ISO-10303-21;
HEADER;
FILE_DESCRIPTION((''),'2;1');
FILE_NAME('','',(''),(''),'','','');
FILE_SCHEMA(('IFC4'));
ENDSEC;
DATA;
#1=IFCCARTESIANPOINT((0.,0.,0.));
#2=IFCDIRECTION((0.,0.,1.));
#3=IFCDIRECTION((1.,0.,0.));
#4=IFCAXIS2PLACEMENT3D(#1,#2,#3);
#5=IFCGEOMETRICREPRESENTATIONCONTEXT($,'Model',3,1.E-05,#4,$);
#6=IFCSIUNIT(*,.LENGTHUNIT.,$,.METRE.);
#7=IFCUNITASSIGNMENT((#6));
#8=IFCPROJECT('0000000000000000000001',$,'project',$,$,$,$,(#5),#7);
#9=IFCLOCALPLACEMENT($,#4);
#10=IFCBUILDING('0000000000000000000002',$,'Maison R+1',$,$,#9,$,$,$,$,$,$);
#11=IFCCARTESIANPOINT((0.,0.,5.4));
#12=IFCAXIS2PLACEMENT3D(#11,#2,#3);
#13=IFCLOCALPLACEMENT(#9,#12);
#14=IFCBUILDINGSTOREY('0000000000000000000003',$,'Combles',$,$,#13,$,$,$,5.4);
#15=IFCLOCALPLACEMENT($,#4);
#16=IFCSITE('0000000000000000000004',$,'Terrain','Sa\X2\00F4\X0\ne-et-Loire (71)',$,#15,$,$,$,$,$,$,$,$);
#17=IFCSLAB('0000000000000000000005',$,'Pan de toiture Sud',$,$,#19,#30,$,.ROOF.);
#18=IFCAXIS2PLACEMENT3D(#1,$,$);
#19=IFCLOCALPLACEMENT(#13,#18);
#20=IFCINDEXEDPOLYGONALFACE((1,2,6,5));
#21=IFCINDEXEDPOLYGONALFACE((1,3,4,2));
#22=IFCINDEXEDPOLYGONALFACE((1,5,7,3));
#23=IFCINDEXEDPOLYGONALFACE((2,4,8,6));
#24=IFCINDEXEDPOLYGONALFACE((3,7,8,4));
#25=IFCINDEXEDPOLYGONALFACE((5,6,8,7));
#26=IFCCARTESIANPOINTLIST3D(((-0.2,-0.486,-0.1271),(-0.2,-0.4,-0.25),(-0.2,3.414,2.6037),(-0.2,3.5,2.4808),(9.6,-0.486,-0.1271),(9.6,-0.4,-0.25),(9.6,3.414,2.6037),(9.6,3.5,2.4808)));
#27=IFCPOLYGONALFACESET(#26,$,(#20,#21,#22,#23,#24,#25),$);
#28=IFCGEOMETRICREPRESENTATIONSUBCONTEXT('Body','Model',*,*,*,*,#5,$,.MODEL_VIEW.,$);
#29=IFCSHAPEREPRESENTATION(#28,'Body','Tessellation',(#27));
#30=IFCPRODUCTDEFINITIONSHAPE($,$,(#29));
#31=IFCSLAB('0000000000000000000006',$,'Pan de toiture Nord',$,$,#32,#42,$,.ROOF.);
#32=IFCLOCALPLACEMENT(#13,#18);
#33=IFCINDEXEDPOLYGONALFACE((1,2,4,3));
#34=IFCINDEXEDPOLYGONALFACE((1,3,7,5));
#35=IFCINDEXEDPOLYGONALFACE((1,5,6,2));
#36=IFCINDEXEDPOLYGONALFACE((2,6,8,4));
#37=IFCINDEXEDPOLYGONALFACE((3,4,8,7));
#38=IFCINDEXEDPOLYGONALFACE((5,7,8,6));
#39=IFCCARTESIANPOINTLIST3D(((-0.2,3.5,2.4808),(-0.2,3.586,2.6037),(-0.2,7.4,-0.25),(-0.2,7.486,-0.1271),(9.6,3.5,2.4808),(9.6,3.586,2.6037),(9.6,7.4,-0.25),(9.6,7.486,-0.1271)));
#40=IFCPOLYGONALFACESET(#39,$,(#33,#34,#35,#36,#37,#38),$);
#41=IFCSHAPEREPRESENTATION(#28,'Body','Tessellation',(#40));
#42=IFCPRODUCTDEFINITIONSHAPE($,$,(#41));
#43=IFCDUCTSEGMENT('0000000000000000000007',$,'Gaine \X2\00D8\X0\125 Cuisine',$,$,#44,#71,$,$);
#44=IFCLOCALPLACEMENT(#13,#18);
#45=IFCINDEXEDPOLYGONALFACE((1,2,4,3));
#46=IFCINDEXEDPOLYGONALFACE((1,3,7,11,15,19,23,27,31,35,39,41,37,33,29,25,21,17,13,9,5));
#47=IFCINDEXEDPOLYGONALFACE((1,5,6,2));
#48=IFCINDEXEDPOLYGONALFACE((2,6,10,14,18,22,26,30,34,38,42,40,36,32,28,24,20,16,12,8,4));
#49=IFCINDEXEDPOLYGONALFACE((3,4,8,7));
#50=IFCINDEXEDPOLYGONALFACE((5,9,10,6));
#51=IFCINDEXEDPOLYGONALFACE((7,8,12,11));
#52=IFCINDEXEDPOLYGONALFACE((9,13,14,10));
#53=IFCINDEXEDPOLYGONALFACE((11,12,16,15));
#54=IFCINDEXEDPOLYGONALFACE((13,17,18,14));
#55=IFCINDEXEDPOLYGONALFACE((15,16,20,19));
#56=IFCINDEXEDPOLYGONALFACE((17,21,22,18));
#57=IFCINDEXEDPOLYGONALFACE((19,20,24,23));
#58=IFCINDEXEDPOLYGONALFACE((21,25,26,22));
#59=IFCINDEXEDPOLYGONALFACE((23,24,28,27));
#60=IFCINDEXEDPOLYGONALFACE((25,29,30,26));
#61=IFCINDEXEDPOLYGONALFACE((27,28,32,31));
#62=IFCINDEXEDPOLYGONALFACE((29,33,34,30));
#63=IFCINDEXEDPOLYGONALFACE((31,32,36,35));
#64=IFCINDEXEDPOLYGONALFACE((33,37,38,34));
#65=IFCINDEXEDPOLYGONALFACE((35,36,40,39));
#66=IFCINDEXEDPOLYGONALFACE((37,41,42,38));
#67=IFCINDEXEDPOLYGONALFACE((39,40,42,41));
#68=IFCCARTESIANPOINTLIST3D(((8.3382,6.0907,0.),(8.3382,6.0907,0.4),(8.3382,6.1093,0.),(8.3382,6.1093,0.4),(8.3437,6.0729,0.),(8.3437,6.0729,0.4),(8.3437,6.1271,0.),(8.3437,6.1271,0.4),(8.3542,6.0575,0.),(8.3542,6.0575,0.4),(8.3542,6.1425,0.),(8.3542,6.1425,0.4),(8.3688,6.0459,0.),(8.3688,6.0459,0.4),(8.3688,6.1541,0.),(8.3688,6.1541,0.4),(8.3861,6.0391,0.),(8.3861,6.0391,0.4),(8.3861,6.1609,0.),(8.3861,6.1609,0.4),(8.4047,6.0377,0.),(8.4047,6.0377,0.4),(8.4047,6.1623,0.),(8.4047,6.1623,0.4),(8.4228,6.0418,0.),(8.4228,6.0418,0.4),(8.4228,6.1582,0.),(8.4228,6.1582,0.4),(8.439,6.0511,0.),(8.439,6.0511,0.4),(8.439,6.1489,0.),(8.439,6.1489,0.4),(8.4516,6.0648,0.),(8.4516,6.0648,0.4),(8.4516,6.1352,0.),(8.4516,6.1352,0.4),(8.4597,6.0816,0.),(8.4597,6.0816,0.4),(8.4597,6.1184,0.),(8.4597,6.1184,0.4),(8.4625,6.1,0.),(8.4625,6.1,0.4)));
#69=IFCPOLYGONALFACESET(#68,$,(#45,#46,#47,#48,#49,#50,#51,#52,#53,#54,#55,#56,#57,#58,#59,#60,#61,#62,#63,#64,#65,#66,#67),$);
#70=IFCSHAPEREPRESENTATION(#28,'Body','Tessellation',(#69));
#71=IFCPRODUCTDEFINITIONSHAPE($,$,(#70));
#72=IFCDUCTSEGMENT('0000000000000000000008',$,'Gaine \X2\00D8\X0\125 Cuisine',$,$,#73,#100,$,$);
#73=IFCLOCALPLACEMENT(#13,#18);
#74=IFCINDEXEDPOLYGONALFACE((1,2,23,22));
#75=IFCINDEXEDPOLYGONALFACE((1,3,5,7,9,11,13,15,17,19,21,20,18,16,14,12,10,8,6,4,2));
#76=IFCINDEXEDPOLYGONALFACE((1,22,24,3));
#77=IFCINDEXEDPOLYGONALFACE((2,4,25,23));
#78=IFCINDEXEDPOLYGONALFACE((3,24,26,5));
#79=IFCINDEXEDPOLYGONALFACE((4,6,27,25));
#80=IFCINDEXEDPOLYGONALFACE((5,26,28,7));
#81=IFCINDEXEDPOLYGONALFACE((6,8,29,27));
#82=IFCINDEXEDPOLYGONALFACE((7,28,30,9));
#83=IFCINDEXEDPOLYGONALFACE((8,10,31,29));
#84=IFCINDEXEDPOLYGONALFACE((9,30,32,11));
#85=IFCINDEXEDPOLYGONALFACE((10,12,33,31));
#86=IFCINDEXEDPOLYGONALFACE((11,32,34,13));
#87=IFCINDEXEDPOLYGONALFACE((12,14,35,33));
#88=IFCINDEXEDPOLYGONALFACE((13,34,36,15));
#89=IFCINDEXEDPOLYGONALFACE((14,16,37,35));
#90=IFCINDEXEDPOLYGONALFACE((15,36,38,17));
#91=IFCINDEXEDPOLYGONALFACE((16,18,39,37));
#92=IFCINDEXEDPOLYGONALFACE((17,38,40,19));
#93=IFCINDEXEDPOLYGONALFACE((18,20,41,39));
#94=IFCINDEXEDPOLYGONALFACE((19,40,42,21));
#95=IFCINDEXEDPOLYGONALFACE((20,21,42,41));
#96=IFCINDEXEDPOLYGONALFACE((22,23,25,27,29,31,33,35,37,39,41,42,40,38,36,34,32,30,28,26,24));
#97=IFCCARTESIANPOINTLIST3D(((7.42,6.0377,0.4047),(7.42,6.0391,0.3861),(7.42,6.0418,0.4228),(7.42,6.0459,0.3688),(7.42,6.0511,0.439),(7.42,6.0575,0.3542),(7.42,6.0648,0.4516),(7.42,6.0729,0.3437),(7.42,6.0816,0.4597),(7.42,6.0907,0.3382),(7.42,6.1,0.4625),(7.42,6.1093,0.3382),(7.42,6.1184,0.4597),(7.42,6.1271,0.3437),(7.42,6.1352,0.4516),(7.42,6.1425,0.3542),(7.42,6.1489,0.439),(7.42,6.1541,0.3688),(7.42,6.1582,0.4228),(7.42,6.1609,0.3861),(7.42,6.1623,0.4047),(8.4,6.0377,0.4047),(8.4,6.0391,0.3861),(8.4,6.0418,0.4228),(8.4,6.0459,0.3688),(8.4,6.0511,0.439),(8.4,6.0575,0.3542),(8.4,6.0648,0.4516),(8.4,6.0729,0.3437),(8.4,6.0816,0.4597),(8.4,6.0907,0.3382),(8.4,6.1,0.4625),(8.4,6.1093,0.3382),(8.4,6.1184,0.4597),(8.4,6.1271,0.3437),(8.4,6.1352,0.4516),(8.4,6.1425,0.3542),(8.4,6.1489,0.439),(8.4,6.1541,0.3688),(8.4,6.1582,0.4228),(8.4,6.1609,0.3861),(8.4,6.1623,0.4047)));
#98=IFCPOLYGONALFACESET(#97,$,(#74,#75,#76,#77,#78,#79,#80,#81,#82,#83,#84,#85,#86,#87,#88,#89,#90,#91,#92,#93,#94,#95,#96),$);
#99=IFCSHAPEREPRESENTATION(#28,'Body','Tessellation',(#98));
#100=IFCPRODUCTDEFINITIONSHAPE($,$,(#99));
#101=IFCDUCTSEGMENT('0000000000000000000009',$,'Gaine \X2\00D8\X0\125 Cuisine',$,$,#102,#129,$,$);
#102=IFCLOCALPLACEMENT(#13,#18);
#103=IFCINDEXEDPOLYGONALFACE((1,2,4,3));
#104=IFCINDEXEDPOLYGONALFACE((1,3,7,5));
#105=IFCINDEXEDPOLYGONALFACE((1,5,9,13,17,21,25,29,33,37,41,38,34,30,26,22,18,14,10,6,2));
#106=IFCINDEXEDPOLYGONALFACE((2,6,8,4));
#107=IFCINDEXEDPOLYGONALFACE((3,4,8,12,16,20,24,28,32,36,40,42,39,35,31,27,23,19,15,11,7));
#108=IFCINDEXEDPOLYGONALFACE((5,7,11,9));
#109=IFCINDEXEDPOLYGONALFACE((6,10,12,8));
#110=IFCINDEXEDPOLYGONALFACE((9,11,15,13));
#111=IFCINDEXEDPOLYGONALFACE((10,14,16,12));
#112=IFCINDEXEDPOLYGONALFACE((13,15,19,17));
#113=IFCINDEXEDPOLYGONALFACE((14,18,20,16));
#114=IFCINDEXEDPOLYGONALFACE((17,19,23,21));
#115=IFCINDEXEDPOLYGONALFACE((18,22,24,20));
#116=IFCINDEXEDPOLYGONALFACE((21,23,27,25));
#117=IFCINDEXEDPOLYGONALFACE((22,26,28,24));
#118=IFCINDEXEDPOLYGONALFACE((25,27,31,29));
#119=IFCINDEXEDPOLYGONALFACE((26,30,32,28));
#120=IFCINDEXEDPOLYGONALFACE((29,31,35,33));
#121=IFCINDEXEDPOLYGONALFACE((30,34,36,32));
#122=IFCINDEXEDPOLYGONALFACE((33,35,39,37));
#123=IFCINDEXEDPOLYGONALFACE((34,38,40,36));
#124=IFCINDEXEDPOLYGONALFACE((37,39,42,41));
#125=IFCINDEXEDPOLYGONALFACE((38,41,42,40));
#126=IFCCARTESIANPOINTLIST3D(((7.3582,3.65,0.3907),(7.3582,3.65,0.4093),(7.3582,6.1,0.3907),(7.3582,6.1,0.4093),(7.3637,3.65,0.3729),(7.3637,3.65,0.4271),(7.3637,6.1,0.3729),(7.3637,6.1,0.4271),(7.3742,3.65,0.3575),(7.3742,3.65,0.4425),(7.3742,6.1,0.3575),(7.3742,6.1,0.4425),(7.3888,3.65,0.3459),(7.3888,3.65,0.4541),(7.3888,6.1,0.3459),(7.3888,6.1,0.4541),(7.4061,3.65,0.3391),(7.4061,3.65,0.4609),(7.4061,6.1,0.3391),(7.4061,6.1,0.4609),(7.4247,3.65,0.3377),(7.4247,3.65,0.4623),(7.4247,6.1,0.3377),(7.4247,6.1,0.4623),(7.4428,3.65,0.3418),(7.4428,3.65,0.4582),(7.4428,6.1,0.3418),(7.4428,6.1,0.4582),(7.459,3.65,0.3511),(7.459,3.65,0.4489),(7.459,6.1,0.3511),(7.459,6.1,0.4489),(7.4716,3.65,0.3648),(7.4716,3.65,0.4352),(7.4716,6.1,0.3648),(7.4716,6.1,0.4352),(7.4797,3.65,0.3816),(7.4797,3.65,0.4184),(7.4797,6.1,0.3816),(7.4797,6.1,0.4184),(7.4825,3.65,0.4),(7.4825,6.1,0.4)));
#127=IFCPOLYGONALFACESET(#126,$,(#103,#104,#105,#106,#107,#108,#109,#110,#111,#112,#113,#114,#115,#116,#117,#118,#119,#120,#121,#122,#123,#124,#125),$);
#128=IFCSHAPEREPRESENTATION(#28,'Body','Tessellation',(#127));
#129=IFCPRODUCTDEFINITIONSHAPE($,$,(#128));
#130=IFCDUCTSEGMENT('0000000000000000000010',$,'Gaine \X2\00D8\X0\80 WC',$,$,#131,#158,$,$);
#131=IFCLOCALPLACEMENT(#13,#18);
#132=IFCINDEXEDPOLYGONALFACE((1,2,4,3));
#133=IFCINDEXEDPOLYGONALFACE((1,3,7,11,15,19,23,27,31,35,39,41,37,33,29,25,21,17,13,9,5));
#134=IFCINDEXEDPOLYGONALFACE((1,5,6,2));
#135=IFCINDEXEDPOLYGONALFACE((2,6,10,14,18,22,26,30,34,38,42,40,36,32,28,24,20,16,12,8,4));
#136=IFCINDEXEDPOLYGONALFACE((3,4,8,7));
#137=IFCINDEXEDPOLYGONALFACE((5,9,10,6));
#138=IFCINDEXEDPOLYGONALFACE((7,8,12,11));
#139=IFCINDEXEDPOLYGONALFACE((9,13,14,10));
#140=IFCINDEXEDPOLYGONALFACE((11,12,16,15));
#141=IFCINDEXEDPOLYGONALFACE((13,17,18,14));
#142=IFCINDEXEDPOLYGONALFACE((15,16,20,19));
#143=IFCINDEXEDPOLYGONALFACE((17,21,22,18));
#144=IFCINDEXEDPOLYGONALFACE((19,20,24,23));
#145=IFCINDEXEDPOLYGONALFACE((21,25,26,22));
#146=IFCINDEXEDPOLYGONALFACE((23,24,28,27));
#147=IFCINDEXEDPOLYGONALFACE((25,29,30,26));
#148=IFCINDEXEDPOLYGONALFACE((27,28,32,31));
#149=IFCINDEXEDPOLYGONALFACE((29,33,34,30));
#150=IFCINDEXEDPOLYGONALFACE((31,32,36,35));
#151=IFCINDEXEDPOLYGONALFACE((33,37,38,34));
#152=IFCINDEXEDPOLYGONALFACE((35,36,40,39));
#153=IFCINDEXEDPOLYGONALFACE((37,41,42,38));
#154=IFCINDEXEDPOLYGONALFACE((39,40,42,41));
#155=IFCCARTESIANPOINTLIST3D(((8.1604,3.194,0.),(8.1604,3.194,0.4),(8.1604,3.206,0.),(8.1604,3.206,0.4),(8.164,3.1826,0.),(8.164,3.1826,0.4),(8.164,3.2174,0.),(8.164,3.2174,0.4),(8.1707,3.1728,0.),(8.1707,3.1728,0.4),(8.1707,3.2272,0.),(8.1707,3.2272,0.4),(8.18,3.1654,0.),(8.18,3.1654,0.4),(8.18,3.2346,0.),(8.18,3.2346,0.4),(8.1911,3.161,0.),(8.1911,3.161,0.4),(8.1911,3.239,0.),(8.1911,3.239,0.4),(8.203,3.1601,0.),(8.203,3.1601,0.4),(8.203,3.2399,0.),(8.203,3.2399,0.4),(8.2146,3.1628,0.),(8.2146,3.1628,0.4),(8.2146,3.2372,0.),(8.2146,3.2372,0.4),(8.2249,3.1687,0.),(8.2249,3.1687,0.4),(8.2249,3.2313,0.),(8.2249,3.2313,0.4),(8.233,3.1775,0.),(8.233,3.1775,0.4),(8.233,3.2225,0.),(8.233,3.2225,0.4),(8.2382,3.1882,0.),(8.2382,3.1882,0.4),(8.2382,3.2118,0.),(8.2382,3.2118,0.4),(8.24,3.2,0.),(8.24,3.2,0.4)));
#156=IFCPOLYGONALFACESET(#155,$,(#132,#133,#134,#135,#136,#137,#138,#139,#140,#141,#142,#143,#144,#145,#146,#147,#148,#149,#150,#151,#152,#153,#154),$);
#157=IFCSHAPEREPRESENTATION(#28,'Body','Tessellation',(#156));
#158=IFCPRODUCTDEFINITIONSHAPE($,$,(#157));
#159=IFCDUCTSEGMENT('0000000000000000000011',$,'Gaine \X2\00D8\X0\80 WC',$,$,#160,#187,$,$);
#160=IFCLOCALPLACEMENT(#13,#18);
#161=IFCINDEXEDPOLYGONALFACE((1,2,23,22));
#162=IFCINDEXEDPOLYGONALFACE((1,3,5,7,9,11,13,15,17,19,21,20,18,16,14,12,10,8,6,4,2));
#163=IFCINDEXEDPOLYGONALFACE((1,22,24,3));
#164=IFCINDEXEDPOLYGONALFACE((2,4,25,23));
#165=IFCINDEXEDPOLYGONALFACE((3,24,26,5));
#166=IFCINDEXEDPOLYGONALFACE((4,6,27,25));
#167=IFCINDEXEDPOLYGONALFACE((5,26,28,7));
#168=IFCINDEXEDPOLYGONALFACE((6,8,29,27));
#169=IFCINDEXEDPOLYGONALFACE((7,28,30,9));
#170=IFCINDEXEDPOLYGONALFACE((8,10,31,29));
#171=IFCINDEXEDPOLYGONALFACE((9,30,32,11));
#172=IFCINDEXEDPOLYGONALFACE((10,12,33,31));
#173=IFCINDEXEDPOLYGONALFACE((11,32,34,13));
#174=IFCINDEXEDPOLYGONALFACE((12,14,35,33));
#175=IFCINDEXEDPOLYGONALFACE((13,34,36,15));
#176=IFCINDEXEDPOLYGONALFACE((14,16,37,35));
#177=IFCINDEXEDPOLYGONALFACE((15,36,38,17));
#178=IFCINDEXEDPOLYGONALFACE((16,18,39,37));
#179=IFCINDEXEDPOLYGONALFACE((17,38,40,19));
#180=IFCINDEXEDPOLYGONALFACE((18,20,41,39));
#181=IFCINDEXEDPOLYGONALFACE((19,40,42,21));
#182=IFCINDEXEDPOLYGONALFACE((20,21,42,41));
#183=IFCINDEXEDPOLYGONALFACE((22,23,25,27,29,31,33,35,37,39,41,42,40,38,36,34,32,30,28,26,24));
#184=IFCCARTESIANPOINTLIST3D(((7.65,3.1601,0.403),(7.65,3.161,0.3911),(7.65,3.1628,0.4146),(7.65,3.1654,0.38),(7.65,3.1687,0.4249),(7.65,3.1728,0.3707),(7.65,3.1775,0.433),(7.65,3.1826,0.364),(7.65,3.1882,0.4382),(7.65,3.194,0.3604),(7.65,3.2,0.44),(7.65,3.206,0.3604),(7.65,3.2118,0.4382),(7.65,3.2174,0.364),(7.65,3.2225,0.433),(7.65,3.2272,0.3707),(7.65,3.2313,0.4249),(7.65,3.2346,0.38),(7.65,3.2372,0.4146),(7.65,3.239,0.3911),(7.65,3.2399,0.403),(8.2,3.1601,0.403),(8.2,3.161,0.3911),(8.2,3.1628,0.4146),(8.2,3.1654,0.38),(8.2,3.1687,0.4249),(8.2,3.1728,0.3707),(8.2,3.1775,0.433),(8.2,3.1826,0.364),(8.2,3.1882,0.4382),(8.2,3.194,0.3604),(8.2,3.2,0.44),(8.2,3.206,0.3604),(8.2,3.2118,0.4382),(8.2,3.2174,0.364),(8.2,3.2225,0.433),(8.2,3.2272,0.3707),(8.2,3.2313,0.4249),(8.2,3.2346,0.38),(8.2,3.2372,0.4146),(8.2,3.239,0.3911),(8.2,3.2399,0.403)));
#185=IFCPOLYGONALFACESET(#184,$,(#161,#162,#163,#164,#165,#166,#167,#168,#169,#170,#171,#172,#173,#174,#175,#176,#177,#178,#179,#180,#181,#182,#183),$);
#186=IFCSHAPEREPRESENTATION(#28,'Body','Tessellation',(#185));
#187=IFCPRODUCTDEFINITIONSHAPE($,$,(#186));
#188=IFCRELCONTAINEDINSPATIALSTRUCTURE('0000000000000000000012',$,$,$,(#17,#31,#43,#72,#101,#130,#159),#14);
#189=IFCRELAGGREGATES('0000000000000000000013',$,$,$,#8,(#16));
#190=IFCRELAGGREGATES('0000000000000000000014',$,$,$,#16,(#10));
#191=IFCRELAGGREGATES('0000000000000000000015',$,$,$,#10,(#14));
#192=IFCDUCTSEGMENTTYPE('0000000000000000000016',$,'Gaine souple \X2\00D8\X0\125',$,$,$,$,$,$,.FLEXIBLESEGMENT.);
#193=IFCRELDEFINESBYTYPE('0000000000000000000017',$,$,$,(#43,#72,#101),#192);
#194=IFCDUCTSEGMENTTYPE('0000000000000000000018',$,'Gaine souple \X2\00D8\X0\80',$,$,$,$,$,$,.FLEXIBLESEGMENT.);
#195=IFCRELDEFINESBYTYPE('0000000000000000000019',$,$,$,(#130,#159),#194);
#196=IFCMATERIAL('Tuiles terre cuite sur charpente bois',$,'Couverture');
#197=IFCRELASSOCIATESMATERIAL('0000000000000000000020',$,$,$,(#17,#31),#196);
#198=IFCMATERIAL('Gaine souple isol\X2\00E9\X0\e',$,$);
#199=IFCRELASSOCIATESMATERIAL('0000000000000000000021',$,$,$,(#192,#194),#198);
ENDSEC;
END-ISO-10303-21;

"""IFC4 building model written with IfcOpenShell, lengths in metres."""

from ifc_helpers import new_model, si_unit, frame, frame_2d, origin_with_axes, place, context, subcontext, project, spatial, rectangle, circle, extrude, material, type_object, element, save


model = new_model("IFC4")

# Units and contexts
model_context = context("Model", 3, precision=1e-05, world=origin_with_axes())
body_context = subcontext(model_context, "Body", "Model", "MODEL_VIEW")
ifc_project = project(units=[si_unit("LENGTHUNIT", "METRE")], contexts=[model_context])

# Site, building, storey
site_placement = place(None, origin_with_axes())
site = spatial("IfcSite", under=ifc_project, at=site_placement, Name="Terrain", Description="Saône-et-Loire (71)")
building_placement = place(None, origin_with_axes())
building = spatial("IfcBuilding", under=site, at=building_placement, Name="Maison R+1")
storey_placement = place(building_placement, frame((0.0, 0.0, 5.4), z_axis=(0.0, 0.0, 1.0), x_axis=(1.0, 0.0, 0.0)))
storey = spatial("IfcBuildingStorey", under=building, at=storey_placement, Name="Combles", Elevation=5.4)

# Slabs
ifc_material_1 = material(Name="Tuiles terre cuite sur charpente bois", Category="Couverture")
for number, where, z_axis, x_axis, name in (
    (1, (-0.2, -0.4, -0.25), (0.0, -0.573576, 0.819152), (1.0, 0.0, 0.0), "Pan de toiture Sud"),
    (2, (-0.2, 3.5, 2.4808), (0.0, 0.573576, 0.819152), (1.0, 0.0, 0.0), "Pan de toiture Nord"),
):
    element("IfcSlab", number, at=place(storey_placement, frame(where, z_axis=z_axis, x_axis=x_axis)), inside=storey, material=ifc_material_1, Name=name, PredefinedType="ROOF", context=body_context, shape_type="SweptSolid", body=[
        extrude(rectangle(XDim=9.8, YDim=4.761, at=frame_2d((4.9, 2.3805))), origin_with_axes(), (0.0, 0.0, 1.0), 0.15),
    ])

# Duct segments
ifc_material_2 = material(Name="Gaine souple isolée")
duct_segment_type_1 = type_object("IfcDuctSegmentType", Name="Gaine souple Ø125", PredefinedType="FLEXIBLESEGMENT", material=ifc_material_2)
duct_segment_1_placement = place(storey_placement, frame((8.4, 6.1, 0.0), z_axis=(0.0, 0.0, 1.0), x_axis=(1.0, 0.0, 0.0)))
element("IfcDuctSegment", 3, at=duct_segment_1_placement, inside=storey, type_object=duct_segment_type_1, Name="Gaine Ø125 Cuisine", context=body_context, shape_type="SweptSolid", body=[
    extrude(circle(Radius=0.0625), origin_with_axes(), (0.0, 0.0, 1.0), 0.4),
])
duct_segment_2_placement = place(storey_placement, frame((8.4, 6.1, 0.4), z_axis=(-1.0, 0.0, 0.0), x_axis=(0.0, 0.0, 1.0)))
element("IfcDuctSegment", 4, at=duct_segment_2_placement, inside=storey, type_object=duct_segment_type_1, Name="Gaine Ø125 Cuisine", context=body_context, shape_type="SweptSolid", body=[
    extrude(circle(Radius=0.0625), origin_with_axes(), (0.0, 0.0, 1.0), 0.98),
])
duct_segment_3_placement = place(storey_placement, frame((7.42, 6.1, 0.4), z_axis=(0.0, -1.0, 0.0), x_axis=(1.0, 0.0, 0.0)))
element("IfcDuctSegment", 5, at=duct_segment_3_placement, inside=storey, type_object=duct_segment_type_1, Name="Gaine Ø125 Cuisine", context=body_context, shape_type="SweptSolid", body=[
    extrude(circle(Radius=0.0625), origin_with_axes(), (0.0, 0.0, 1.0), 2.45),
])
duct_segment_type_2 = type_object("IfcDuctSegmentType", Name="Gaine souple Ø80", PredefinedType="FLEXIBLESEGMENT", material=ifc_material_2)
duct_segment_4_placement = place(storey_placement, frame((8.2, 3.2, 0.0), z_axis=(0.0, 0.0, 1.0), x_axis=(1.0, 0.0, 0.0)))
element("IfcDuctSegment", 6, at=duct_segment_4_placement, inside=storey, type_object=duct_segment_type_2, Name="Gaine Ø80 WC", context=body_context, shape_type="SweptSolid", body=[
    extrude(circle(Radius=0.04), origin_with_axes(), (0.0, 0.0, 1.0), 0.4),
])
duct_segment_5_placement = place(storey_placement, frame((8.2, 3.2, 0.4), z_axis=(-1.0, 0.0, 0.0), x_axis=(0.0, 0.0, 1.0)))
element("IfcDuctSegment", 7, at=duct_segment_5_placement, inside=storey, type_object=duct_segment_type_2, Name="Gaine Ø80 WC", context=body_context, shape_type="SweptSolid", body=[
    extrude(circle(Radius=0.04), origin_with_axes(), (0.0, 0.0, 1.0), 0.55),
])

save(model, "model.ifc")
